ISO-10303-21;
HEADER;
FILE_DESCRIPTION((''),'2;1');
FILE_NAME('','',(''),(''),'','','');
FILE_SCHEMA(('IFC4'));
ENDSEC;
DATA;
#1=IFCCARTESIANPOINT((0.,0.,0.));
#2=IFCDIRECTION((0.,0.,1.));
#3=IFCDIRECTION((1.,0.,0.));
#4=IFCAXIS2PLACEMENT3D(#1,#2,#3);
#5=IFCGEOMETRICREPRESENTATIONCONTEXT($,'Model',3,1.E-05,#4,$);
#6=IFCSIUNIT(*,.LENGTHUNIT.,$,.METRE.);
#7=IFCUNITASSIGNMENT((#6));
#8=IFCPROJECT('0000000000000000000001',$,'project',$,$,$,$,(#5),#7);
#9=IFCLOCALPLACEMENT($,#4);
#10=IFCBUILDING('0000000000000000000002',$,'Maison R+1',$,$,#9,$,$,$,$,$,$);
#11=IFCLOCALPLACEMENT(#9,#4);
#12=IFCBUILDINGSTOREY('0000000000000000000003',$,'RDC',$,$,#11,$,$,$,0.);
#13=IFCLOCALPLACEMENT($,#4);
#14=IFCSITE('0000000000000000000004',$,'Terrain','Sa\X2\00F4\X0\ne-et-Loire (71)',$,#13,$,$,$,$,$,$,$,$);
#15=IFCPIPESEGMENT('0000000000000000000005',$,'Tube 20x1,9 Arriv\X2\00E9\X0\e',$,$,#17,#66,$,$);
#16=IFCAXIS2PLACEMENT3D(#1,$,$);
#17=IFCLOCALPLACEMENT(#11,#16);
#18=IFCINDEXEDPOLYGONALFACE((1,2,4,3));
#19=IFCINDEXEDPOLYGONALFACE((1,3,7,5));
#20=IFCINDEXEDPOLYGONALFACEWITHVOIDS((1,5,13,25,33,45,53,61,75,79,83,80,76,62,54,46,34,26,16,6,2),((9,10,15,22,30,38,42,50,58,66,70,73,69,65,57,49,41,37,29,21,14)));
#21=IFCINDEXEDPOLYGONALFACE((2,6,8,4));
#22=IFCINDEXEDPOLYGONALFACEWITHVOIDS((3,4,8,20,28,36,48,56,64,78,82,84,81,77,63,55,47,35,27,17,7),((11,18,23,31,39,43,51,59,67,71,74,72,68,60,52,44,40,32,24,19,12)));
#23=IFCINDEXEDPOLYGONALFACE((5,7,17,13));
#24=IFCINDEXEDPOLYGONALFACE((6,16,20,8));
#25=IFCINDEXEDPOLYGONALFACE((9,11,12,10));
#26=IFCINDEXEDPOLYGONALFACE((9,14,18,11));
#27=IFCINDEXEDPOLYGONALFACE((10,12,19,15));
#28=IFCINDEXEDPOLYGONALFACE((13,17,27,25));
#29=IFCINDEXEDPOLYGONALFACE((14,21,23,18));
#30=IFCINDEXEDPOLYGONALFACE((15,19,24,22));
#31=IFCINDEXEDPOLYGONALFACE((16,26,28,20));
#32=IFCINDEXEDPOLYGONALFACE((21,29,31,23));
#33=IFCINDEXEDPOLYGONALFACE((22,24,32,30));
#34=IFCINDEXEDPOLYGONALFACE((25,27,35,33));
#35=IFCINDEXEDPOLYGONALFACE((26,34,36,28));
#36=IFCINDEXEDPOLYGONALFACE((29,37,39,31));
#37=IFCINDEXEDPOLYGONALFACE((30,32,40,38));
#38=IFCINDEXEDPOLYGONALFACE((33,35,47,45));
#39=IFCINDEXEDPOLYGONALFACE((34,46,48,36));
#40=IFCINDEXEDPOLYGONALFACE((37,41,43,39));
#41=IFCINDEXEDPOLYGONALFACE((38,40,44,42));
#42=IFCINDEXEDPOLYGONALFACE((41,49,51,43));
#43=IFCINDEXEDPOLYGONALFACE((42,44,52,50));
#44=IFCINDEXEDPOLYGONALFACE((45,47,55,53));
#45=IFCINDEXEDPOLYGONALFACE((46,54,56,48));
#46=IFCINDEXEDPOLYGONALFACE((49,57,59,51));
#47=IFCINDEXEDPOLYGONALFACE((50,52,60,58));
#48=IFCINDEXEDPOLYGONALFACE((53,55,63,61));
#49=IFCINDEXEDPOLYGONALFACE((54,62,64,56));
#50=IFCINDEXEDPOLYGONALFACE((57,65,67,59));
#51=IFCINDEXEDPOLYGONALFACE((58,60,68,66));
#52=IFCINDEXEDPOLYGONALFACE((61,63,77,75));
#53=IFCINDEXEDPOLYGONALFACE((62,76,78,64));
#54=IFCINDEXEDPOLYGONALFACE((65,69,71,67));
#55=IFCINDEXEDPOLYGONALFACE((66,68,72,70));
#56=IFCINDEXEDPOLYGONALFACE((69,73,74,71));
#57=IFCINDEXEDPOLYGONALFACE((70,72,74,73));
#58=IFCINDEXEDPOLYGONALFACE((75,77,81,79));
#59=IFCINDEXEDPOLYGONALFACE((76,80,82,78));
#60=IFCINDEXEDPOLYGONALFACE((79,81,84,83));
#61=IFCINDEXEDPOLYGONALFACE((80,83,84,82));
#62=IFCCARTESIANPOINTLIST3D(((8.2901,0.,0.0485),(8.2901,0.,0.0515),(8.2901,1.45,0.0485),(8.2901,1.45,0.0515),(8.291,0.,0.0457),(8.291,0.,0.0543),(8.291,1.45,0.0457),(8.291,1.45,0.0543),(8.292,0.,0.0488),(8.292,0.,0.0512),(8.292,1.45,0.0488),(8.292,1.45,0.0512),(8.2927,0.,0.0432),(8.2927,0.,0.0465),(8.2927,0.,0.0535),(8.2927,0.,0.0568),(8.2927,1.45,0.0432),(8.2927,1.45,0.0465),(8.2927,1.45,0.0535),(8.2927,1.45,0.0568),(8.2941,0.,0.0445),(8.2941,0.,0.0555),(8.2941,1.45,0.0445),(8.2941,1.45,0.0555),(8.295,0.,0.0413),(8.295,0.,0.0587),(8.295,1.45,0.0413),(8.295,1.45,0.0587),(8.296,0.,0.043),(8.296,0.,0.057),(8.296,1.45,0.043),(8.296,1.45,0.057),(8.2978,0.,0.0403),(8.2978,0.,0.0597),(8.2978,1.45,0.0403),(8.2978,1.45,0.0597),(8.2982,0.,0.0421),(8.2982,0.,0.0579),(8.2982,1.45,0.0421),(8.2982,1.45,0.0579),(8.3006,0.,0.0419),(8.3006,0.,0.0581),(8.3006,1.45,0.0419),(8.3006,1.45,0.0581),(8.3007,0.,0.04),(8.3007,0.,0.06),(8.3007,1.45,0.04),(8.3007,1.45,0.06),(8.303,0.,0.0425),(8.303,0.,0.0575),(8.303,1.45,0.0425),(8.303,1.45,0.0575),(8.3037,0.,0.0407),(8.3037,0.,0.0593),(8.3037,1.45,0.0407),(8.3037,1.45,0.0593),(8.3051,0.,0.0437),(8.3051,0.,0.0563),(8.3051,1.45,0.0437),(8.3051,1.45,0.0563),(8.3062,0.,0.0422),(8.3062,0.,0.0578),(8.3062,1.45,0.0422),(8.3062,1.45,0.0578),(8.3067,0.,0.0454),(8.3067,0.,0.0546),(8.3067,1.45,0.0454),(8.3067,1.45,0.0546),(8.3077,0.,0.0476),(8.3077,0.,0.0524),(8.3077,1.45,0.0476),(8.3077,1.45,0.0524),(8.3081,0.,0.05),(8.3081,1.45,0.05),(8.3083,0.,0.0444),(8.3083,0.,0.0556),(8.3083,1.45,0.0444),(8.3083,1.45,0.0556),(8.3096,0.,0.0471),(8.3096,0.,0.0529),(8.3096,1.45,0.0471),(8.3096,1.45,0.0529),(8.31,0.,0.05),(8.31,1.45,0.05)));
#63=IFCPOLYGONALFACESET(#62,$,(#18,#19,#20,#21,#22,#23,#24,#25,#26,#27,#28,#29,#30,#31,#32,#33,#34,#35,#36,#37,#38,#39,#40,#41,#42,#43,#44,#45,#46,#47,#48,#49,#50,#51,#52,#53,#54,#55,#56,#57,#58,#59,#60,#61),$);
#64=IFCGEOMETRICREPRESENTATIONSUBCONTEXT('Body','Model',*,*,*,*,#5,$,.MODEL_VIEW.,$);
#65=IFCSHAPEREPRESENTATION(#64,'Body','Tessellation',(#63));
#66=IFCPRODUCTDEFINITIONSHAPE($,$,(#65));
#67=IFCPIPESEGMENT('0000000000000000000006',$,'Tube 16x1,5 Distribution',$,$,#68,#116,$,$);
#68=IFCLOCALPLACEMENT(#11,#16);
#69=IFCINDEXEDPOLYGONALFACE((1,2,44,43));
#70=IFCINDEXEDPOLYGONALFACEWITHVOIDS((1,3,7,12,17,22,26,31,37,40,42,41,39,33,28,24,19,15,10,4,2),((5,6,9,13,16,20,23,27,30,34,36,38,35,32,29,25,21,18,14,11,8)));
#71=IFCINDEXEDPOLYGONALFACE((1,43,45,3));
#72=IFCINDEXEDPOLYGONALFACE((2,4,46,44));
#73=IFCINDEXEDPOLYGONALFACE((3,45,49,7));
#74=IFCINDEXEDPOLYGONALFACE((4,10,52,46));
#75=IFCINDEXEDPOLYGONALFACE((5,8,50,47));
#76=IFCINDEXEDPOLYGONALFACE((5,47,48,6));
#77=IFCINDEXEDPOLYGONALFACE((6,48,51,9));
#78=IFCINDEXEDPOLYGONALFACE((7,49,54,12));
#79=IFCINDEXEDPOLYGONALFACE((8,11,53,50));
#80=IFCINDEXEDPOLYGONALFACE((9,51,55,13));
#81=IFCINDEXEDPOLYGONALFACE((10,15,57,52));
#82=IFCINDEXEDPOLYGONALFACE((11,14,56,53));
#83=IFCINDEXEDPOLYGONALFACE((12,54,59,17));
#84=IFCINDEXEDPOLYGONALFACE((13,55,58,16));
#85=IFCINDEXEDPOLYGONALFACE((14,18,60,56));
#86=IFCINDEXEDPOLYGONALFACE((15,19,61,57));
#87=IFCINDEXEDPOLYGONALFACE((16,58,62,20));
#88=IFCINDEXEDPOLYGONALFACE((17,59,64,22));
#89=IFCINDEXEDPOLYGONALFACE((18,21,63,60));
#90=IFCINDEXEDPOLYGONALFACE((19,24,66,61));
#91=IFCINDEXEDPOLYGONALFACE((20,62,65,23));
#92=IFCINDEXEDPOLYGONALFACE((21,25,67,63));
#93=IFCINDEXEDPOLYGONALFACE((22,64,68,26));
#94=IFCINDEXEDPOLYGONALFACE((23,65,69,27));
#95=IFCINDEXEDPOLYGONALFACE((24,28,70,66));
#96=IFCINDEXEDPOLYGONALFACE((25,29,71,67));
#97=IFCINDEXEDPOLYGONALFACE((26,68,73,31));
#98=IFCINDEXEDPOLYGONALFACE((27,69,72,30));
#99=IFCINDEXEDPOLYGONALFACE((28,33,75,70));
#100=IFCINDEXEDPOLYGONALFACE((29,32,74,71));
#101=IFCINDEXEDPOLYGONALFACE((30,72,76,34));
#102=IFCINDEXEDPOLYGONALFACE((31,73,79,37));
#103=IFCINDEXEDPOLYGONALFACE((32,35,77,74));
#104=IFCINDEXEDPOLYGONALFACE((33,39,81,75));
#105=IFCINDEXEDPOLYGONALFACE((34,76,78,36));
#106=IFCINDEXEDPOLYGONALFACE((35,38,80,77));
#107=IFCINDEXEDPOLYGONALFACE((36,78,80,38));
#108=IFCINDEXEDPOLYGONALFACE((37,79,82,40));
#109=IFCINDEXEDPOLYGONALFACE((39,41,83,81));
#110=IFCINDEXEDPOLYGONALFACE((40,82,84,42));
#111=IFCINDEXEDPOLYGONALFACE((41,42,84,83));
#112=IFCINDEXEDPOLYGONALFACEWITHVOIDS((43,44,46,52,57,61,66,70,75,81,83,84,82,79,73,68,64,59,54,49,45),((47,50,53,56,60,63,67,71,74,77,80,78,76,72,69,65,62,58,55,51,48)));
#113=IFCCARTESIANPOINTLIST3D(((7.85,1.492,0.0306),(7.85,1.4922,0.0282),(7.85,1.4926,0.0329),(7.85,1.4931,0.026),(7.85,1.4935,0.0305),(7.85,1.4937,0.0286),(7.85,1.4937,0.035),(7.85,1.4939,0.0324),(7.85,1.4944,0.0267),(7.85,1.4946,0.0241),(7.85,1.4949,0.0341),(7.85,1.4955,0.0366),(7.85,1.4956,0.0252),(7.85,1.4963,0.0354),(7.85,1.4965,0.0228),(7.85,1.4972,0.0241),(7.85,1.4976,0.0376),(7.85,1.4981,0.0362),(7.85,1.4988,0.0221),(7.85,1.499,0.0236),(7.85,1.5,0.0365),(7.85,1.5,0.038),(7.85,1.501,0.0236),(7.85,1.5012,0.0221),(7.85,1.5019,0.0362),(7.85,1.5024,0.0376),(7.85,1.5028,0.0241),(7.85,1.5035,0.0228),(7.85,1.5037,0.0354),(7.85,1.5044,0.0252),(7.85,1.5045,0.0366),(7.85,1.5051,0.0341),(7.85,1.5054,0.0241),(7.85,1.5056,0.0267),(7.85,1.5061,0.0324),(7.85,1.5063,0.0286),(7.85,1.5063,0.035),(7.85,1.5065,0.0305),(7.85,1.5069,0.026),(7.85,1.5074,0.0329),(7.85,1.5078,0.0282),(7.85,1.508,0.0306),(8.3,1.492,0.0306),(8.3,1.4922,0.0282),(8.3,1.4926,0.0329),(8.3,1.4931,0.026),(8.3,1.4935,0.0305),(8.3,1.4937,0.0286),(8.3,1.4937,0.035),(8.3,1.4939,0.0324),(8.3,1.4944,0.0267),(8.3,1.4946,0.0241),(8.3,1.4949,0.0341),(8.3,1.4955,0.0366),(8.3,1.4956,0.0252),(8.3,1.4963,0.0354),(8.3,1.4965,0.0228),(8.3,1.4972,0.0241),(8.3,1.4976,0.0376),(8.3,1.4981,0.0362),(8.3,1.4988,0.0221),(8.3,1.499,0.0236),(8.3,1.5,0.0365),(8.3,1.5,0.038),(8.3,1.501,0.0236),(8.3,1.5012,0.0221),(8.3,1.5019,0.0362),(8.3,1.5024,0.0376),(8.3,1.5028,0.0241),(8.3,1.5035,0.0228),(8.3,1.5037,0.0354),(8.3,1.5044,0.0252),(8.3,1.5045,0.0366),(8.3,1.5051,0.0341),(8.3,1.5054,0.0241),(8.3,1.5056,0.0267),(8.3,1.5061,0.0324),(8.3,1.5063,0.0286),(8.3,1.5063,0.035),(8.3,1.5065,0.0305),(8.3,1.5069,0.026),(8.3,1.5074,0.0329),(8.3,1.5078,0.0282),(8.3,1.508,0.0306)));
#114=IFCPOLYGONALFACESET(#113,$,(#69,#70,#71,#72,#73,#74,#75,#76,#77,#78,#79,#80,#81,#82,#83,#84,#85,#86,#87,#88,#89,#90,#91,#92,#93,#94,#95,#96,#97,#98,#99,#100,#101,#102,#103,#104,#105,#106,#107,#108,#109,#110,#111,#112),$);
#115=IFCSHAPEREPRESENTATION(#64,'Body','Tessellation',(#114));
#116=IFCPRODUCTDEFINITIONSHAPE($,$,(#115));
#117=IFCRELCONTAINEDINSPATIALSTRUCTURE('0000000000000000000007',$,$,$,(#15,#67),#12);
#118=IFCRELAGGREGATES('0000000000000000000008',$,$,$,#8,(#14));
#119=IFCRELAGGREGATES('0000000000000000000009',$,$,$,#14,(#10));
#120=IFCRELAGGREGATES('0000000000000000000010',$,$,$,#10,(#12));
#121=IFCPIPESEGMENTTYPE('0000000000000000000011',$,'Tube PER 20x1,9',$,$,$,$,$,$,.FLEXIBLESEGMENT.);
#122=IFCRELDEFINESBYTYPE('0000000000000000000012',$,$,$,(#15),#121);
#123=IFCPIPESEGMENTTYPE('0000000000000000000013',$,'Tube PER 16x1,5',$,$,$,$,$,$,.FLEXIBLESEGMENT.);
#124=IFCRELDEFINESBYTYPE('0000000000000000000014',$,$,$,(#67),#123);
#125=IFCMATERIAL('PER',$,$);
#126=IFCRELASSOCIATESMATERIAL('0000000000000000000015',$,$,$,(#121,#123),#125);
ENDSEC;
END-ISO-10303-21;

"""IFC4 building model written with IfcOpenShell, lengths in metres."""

from ifc_helpers import new_model, si_unit, frame, origin_with_axes, place, context, subcontext, project, spatial, hollow_circle, extrude, material, type_object, element, save


model = new_model("IFC4")

# Units and contexts
model_context = context("Model", 3, precision=1e-05, world=origin_with_axes())
body_context = subcontext(model_context, "Body", "Model", "MODEL_VIEW")
ifc_project = project(units=[si_unit("LENGTHUNIT", "METRE")], contexts=[model_context])

# Site, building, storey
site_placement = place(None, origin_with_axes())
site = spatial("IfcSite", under=ifc_project, at=site_placement, Name="Terrain", Description="Saône-et-Loire (71)")
building_placement = place(None, origin_with_axes())
building = spatial("IfcBuilding", under=site, at=building_placement, Name="Maison R+1")
storey_placement = place(building_placement, origin_with_axes())
storey = spatial("IfcBuildingStorey", under=building, at=storey_placement, Name="RDC", Elevation=0.0)

# Pipe segments
ifc_material_1 = material(Name="PER")
pipe_segment_type_1 = type_object("IfcPipeSegmentType", Name="Tube PER 20x1,9", PredefinedType="FLEXIBLESEGMENT", material=ifc_material_1)
pipe_segment_1_placement = place(storey_placement, frame((8.3, 0.0, 0.05), z_axis=(0.0, 1.0, 0.0), x_axis=(1.0, 0.0, 0.0)))
element("IfcPipeSegment", 1, at=pipe_segment_1_placement, inside=storey, type_object=pipe_segment_type_1, Name="Tube 20x1,9 Arrivée", context=body_context, shape_type="SweptSolid", body=[
    extrude(hollow_circle(Radius=0.01, WallThickness=0.0019), origin_with_axes(), (0.0, 0.0, 1.0), 1.45),
])
pipe_segment_type_2 = type_object("IfcPipeSegmentType", Name="Tube PER 16x1,5", PredefinedType="FLEXIBLESEGMENT", material=ifc_material_1)
pipe_segment_2_placement = place(storey_placement, frame((8.3, 1.5, 0.03), z_axis=(-1.0, 0.0, 0.0), x_axis=(0.0, 0.0, 1.0)))
element("IfcPipeSegment", 2, at=pipe_segment_2_placement, inside=storey, type_object=pipe_segment_type_2, Name="Tube 16x1,5 Distribution", context=body_context, shape_type="SweptSolid", body=[
    extrude(hollow_circle(Radius=0.008, WallThickness=0.0015), origin_with_axes(), (0.0, 0.0, 1.0), 0.45),
])

save(model, "model.ifc")
